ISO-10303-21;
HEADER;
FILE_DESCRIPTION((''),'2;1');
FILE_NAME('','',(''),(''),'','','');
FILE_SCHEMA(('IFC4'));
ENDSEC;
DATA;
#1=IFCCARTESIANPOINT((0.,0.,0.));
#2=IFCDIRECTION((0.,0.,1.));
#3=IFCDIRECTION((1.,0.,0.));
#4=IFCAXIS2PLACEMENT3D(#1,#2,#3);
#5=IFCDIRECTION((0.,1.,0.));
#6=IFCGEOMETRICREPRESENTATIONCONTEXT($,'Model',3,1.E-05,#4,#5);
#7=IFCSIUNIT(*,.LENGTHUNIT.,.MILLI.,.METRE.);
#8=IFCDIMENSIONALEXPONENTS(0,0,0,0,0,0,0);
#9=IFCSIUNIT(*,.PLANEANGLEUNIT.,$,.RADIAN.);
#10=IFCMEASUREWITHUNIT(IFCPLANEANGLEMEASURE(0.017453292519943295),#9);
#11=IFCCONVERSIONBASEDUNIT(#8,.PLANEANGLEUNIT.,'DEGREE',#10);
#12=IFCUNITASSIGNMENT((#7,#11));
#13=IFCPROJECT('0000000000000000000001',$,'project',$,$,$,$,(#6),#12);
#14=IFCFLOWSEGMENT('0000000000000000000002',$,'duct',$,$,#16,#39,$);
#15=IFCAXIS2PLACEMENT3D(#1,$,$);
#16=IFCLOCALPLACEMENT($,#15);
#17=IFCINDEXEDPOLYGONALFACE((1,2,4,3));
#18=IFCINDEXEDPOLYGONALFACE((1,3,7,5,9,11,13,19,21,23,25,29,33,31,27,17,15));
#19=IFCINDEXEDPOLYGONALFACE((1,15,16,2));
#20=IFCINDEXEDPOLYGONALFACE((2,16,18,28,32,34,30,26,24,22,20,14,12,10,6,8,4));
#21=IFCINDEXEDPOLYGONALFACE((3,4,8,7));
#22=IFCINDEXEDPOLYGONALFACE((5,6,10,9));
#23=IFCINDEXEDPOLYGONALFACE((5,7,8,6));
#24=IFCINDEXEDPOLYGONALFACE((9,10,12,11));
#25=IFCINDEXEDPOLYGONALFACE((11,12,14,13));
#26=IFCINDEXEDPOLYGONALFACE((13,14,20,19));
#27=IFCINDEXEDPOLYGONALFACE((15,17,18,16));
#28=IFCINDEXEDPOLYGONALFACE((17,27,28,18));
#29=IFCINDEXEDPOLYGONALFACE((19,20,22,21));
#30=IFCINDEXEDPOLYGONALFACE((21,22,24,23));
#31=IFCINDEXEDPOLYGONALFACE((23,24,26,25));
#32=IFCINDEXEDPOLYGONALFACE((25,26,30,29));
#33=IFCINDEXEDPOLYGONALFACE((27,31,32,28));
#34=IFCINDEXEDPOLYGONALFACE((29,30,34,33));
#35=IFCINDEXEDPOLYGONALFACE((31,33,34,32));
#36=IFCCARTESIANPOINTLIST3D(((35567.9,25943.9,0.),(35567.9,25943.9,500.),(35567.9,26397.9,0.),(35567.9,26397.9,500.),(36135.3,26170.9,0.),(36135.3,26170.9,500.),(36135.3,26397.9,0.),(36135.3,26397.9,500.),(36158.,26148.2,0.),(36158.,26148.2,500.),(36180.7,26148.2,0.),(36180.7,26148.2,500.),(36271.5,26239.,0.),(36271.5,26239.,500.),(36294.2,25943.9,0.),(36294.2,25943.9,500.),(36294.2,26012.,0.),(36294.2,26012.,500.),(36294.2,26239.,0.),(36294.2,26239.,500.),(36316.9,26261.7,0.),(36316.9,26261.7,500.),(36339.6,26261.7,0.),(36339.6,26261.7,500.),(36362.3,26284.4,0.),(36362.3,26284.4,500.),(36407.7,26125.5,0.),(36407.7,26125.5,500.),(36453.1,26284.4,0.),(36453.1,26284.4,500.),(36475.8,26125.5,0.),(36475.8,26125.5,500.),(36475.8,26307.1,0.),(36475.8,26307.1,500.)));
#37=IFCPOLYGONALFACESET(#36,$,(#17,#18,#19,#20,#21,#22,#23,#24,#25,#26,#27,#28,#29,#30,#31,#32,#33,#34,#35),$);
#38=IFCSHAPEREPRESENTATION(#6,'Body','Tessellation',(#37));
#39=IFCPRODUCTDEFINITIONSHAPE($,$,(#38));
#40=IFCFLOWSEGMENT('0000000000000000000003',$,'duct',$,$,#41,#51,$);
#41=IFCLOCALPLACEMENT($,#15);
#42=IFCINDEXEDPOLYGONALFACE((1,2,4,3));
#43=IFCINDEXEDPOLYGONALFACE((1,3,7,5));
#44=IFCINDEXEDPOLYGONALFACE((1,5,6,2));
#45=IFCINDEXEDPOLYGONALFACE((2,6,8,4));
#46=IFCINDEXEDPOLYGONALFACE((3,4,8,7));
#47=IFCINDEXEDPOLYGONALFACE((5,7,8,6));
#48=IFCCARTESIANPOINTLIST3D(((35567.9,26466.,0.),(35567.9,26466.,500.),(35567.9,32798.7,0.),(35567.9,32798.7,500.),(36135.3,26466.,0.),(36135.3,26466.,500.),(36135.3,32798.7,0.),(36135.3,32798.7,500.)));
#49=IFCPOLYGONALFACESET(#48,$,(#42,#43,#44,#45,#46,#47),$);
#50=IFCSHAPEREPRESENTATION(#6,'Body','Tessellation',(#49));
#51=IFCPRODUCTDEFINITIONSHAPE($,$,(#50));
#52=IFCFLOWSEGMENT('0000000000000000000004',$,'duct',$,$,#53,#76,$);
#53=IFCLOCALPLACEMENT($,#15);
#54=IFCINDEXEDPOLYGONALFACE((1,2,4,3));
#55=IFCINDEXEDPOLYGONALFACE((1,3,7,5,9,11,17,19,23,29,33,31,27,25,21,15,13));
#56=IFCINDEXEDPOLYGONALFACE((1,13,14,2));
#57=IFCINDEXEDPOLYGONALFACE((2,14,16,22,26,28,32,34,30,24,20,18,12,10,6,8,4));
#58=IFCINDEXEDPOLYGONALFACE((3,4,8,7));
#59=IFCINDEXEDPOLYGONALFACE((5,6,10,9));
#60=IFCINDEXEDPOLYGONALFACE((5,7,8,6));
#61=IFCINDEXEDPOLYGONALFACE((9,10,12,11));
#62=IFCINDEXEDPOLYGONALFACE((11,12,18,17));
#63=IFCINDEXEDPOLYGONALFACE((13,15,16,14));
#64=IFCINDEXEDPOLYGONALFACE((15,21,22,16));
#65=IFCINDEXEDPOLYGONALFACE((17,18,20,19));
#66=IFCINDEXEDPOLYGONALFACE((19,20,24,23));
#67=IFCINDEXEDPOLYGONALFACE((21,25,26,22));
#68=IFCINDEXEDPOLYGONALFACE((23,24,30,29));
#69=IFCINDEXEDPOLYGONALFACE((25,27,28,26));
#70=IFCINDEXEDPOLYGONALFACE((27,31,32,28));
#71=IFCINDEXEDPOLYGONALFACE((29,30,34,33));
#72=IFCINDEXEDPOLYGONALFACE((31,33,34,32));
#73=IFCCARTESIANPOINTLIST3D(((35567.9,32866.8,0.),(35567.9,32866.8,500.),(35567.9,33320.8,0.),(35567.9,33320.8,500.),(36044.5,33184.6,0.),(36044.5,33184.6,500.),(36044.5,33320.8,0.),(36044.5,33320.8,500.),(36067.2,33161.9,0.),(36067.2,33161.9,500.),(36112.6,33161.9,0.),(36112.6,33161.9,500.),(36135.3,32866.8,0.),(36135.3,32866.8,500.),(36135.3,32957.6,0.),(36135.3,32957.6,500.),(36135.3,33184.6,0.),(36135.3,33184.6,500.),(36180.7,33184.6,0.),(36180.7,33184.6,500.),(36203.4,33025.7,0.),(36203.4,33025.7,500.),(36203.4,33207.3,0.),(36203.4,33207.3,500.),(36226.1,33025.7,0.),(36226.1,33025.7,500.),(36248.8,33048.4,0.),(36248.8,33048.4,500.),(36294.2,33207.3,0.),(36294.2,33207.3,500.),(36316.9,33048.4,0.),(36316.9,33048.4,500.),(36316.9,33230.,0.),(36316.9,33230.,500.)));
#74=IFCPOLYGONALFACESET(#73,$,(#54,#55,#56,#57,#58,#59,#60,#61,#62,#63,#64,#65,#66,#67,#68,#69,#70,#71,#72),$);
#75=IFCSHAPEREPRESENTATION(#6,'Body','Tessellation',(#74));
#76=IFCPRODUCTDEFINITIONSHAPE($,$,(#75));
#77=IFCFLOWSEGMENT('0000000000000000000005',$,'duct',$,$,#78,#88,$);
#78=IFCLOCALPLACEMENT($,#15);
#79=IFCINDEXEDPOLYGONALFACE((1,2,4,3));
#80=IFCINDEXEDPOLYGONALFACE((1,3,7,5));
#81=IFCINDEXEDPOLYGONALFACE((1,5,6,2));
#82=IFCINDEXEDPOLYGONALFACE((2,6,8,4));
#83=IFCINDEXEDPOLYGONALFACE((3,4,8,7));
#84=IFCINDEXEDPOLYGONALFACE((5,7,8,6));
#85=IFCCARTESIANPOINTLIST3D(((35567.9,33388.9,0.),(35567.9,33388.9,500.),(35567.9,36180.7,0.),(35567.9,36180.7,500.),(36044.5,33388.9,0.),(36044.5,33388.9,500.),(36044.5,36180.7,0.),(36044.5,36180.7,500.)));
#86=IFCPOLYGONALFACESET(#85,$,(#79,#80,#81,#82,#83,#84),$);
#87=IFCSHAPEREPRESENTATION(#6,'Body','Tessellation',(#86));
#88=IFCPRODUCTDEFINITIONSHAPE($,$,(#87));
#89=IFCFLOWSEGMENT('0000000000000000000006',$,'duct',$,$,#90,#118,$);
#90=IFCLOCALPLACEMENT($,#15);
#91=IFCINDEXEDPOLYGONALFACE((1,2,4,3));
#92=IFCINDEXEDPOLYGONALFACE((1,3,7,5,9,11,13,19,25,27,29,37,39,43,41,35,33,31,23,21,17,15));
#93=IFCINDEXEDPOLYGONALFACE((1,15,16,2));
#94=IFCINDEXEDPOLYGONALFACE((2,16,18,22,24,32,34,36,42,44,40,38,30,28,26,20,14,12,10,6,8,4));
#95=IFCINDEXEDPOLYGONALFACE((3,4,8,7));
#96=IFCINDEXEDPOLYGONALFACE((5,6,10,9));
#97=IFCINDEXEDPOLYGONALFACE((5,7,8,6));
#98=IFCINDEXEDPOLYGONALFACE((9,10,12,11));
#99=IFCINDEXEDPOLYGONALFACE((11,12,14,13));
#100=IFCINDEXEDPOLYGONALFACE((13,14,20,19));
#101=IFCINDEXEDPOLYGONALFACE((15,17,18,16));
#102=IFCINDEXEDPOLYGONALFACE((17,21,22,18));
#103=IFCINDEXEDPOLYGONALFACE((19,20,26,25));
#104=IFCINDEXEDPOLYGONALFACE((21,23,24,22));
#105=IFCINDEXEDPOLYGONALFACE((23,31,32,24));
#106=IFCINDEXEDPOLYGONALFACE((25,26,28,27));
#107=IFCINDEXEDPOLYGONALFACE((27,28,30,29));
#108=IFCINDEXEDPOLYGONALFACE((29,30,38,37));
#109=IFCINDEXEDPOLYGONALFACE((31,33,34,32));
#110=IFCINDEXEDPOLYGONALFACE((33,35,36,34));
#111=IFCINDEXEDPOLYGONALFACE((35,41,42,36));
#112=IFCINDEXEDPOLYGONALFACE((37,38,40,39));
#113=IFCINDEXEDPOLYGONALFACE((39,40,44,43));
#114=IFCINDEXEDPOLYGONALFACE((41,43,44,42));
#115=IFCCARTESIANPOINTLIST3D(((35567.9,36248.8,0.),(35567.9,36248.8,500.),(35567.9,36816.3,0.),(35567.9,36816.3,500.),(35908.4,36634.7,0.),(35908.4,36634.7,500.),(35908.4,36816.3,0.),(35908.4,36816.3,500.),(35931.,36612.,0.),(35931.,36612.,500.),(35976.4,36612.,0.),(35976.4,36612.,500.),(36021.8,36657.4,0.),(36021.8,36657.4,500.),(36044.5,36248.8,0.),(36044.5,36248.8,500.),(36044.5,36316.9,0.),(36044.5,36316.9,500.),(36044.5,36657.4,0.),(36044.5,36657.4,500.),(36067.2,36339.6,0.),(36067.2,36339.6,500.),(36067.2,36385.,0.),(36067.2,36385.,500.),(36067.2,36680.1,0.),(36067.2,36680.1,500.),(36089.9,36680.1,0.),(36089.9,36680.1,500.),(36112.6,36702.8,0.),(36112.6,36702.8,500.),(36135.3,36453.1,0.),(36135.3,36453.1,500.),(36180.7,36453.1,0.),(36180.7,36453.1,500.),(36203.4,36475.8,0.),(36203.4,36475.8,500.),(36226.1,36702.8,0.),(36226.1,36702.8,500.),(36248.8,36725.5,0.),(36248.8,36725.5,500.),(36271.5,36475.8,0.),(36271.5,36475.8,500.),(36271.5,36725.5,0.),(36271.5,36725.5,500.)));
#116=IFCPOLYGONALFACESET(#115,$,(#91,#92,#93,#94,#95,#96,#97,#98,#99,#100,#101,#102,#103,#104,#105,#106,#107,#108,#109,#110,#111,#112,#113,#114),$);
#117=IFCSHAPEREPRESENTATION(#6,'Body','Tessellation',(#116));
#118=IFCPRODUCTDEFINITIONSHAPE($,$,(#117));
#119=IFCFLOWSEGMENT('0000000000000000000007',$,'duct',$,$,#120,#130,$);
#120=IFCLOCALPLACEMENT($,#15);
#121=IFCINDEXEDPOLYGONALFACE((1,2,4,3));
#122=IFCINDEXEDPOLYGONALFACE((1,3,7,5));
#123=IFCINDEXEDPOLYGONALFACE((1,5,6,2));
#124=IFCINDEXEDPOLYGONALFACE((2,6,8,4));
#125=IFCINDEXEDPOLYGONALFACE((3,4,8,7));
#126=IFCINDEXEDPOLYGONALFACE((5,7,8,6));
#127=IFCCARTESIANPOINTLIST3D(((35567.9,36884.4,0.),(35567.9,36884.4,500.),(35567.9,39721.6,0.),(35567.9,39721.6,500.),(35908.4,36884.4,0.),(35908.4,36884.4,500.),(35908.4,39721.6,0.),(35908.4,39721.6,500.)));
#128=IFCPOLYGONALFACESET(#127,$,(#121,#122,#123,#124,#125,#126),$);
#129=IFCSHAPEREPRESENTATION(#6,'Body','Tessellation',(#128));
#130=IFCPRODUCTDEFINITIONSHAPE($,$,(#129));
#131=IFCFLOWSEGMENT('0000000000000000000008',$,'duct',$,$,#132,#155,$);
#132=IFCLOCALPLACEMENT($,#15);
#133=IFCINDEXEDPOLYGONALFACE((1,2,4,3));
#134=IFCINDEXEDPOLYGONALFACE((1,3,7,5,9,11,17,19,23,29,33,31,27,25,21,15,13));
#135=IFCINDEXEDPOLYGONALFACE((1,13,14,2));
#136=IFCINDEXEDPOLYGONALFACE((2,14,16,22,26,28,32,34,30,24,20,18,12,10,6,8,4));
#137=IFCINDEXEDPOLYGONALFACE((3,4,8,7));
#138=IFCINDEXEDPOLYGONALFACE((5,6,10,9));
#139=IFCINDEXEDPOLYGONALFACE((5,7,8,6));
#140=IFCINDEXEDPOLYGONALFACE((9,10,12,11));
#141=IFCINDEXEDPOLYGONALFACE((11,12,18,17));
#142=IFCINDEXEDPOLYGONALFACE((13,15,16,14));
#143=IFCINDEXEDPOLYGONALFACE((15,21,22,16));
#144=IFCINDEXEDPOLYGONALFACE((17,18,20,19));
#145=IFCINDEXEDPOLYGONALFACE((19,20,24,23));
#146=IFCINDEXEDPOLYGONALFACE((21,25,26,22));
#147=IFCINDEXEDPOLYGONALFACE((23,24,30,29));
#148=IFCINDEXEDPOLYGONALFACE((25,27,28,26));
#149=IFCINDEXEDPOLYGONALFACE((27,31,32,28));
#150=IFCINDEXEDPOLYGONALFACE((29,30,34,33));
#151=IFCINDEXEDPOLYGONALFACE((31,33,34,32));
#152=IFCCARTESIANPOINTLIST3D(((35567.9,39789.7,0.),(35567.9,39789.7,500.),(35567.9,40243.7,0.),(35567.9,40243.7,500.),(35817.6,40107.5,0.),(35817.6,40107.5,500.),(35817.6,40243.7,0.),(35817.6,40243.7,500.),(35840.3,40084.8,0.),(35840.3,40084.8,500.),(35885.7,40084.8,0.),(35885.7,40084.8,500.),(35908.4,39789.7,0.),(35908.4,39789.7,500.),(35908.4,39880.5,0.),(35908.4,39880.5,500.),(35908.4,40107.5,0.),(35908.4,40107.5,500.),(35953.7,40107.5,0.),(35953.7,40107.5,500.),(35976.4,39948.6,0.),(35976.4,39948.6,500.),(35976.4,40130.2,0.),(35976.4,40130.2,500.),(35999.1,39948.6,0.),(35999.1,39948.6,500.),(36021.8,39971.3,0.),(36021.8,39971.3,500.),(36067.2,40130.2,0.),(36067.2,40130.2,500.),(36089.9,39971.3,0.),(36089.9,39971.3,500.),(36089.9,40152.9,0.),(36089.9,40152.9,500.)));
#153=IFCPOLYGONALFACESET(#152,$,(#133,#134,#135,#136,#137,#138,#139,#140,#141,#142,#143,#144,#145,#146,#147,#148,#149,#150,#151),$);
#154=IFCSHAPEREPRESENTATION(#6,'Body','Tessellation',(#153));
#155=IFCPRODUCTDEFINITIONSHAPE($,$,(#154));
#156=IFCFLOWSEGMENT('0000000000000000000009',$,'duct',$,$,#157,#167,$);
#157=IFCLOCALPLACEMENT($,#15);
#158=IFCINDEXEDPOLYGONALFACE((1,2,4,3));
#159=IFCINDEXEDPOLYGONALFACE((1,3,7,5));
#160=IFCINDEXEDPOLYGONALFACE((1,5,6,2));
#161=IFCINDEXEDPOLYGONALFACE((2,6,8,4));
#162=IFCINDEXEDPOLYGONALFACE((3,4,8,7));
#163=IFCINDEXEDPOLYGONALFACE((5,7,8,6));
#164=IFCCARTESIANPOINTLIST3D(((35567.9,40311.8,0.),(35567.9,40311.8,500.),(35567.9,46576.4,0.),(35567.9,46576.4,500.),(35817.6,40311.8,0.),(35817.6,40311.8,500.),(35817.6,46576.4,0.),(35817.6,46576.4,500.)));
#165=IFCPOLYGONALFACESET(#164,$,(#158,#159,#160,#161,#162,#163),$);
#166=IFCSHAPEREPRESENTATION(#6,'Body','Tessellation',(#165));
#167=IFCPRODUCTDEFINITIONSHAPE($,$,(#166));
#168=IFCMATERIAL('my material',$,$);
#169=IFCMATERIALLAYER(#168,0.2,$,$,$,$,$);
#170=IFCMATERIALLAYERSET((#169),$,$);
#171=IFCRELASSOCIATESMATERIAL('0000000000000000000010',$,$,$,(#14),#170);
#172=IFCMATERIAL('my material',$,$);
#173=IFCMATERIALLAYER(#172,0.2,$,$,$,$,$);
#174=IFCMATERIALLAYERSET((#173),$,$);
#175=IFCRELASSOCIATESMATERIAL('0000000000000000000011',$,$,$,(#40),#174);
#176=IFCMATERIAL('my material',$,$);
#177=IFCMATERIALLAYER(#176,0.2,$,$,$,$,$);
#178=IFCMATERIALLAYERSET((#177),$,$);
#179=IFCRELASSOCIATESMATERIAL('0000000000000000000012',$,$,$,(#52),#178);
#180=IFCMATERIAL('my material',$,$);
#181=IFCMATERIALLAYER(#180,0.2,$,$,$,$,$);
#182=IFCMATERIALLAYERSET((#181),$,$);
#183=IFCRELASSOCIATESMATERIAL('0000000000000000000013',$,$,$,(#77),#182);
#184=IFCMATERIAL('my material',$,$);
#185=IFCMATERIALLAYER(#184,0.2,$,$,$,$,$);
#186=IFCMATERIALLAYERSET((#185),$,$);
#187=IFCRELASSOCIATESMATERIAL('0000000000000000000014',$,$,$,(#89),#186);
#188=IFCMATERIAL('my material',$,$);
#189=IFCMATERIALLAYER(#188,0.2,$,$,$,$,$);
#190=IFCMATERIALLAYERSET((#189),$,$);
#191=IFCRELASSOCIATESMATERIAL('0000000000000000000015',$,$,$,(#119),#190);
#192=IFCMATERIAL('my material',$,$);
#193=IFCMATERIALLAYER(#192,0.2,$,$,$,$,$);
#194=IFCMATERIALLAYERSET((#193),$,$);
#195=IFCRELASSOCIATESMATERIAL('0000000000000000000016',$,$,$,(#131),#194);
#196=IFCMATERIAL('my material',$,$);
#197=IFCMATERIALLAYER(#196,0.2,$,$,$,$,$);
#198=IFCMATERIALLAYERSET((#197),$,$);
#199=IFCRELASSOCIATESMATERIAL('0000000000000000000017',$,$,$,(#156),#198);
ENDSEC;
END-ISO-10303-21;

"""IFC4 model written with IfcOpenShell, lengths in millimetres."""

from ifc_helpers import new_model, entity, si_unit, converted_unit, direction, origin_with_axes, place, context, project, polyline, outline, extrude, material, layer, layer_set, layer_usage, element, save


model = new_model("IFC4")

# Units and contexts
model_context = context("Model", 3, precision=1e-05, world=origin_with_axes(), true_north=direction((0.0, 1.0, 0.0)))
ifc_project = project(units=[si_unit("LENGTHUNIT", "METRE", prefix="MILLI"), converted_unit("PLANEANGLEUNIT", "DEGREE", entity("IfcPlaneAngleMeasure", 0.017453292519943295), si_unit("PLANEANGLEUNIT", "RADIAN"), dimensions=[0, 0, 0, 0, 0, 0, 0])], contexts=[model_context])

# Flow segments
ifc_material_1 = material(Name="my material")
ifc_layer_1 = layer(ifc_material_1, 0.2)
ifc_layer_set_1 = layer_set([ifc_layer_1])
ifc_layer_usage_1 = layer_usage(ifc_layer_set_1, "AXIS2", "POSITIVE", -0.1)
flow_segment_1_placement = place(None, origin_with_axes())
element("IfcFlowSegment", 1, at=flow_segment_1_placement, material=ifc_layer_usage_1, Name="duct", context=model_context, shape_type="SweptSolid", body=[
    extrude(outline(polyline([(35567.9, 25943.9), (36294.2, 25943.9), (36294.2, 26012.0), (36407.7, 26125.5), (36475.8, 26125.5), (36475.8, 26307.1), (36453.1, 26284.4), (36362.3, 26284.4), (36339.6, 26261.7), (36316.9, 26261.7), (36294.2, 26239.0), (36271.5, 26239.0), (36180.7, 26148.2), (36158.0, 26148.2), (36135.3, 26170.9), (36135.3, 26397.9), (35567.9, 26397.9), (35567.9, 25943.9)])), origin_with_axes(), (0.0, 0.0, 1.0), 500.0),
])
ifc_material_2 = material(Name="my material")
ifc_layer_2 = layer(ifc_material_2, 0.2)
ifc_layer_set_2 = layer_set([ifc_layer_2])
ifc_layer_usage_2 = layer_usage(ifc_layer_set_2, "AXIS2", "POSITIVE", -0.1)
flow_segment_2_placement = place(None, origin_with_axes())
element("IfcFlowSegment", 2, at=flow_segment_2_placement, material=ifc_layer_usage_2, Name="duct", context=model_context, shape_type="SweptSolid", body=[
    extrude(outline(polyline([(35567.9, 26466.0), (36135.3, 26466.0), (36135.3, 32798.7), (35567.9, 32798.7), (35567.9, 26466.0)])), origin_with_axes(), (0.0, 0.0, 1.0), 500.0),
])
ifc_material_3 = material(Name="my material")
ifc_layer_3 = layer(ifc_material_3, 0.2)
ifc_layer_set_3 = layer_set([ifc_layer_3])
ifc_layer_usage_3 = layer_usage(ifc_layer_set_3, "AXIS2", "POSITIVE", -0.1)
flow_segment_3_placement = place(None, origin_with_axes())
element("IfcFlowSegment", 3, at=flow_segment_3_placement, material=ifc_layer_usage_3, Name="duct", context=model_context, shape_type="SweptSolid", body=[
    extrude(outline(polyline([(35567.9, 32866.8), (36135.3, 32866.8), (36135.3, 32957.6), (36203.4, 33025.7), (36226.1, 33025.7), (36248.8, 33048.4), (36316.9, 33048.4), (36316.9, 33230.0), (36294.2, 33207.3), (36203.4, 33207.3), (36180.7, 33184.6), (36135.3, 33184.6), (36112.6, 33161.9), (36067.2, 33161.9), (36044.5, 33184.6), (36044.5, 33320.8), (35567.9, 33320.8), (35567.9, 32866.8)])), origin_with_axes(), (0.0, 0.0, 1.0), 500.0),
])
ifc_material_4 = material(Name="my material")
ifc_layer_4 = layer(ifc_material_4, 0.2)
ifc_layer_set_4 = layer_set([ifc_layer_4])
ifc_layer_usage_4 = layer_usage(ifc_layer_set_4, "AXIS2", "POSITIVE", -0.1)
flow_segment_4_placement = place(None, origin_with_axes())
element("IfcFlowSegment", 4, at=flow_segment_4_placement, material=ifc_layer_usage_4, Name="duct", context=model_context, shape_type="SweptSolid", body=[
    extrude(outline(polyline([(35567.9, 33388.9), (36044.5, 33388.9), (36044.5, 36180.7), (35567.9, 36180.7), (35567.9, 33388.9)])), origin_with_axes(), (0.0, 0.0, 1.0), 500.0),
])
ifc_material_5 = material(Name="my material")
ifc_layer_5 = layer(ifc_material_5, 0.2)
ifc_layer_set_5 = layer_set([ifc_layer_5])
ifc_layer_usage_5 = layer_usage(ifc_layer_set_5, "AXIS2", "POSITIVE", -0.1)
flow_segment_5_placement = place(None, origin_with_axes())
element("IfcFlowSegment", 5, at=flow_segment_5_placement, material=ifc_layer_usage_5, Name="duct", context=model_context, shape_type="SweptSolid", body=[
    extrude(outline(polyline([(35567.9, 36248.8), (36044.5, 36248.8), (36044.5, 36316.9), (36067.2, 36339.6), (36067.2, 36385.0), (36135.3, 36453.1), (36180.7, 36453.1), (36203.4, 36475.8), (36271.5, 36475.8), (36271.5, 36725.5), (36248.8, 36725.5), (36226.1, 36702.8), (36112.6, 36702.8), (36089.9, 36680.1), (36067.2, 36680.1), (36044.5, 36657.4), (36021.8, 36657.4), (35976.4, 36612.0), (35931.0, 36612.0), (35908.4, 36634.7), (35908.4, 36816.3), (35567.9, 36816.3), (35567.9, 36248.8)])), origin_with_axes(), (0.0, 0.0, 1.0), 500.0),
])
ifc_material_6 = material(Name="my material")
ifc_layer_6 = layer(ifc_material_6, 0.2)
ifc_layer_set_6 = layer_set([ifc_layer_6])
ifc_layer_usage_6 = layer_usage(ifc_layer_set_6, "AXIS2", "POSITIVE", -0.1)
flow_segment_6_placement = place(None, origin_with_axes())
element("IfcFlowSegment", 6, at=flow_segment_6_placement, material=ifc_layer_usage_6, Name="duct", context=model_context, shape_type="SweptSolid", body=[
    extrude(outline(polyline([(35567.9, 36884.4), (35908.4, 36884.4), (35908.4, 39721.6), (35567.9, 39721.6), (35567.9, 36884.4)])), origin_with_axes(), (0.0, 0.0, 1.0), 500.0),
])
ifc_material_7 = material(Name="my material")
ifc_layer_7 = layer(ifc_material_7, 0.2)
ifc_layer_set_7 = layer_set([ifc_layer_7])
ifc_layer_usage_7 = layer_usage(ifc_layer_set_7, "AXIS2", "POSITIVE", -0.1)
flow_segment_7_placement = place(None, origin_with_axes())
element("IfcFlowSegment", 7, at=flow_segment_7_placement, material=ifc_layer_usage_7, Name="duct", context=model_context, shape_type="SweptSolid", body=[
    extrude(outline(polyline([(35567.9, 39789.7), (35908.4, 39789.7), (35908.4, 39880.5), (35976.4, 39948.6), (35999.1, 39948.6), (36021.8, 39971.3), (36089.9, 39971.3), (36089.9, 40152.9), (36067.2, 40130.2), (35976.4, 40130.2), (35953.7, 40107.5), (35908.4, 40107.5), (35885.7, 40084.8), (35840.3, 40084.8), (35817.6, 40107.5), (35817.6, 40243.7), (35567.9, 40243.7), (35567.9, 39789.7)])), origin_with_axes(), (0.0, 0.0, 1.0), 500.0),
])
ifc_material_8 = material(Name="my material")
ifc_layer_8 = layer(ifc_material_8, 0.2)
ifc_layer_set_8 = layer_set([ifc_layer_8])
ifc_layer_usage_8 = layer_usage(ifc_layer_set_8, "AXIS2", "POSITIVE", -0.1)
flow_segment_8_placement = place(None, origin_with_axes())
element("IfcFlowSegment", 8, at=flow_segment_8_placement, material=ifc_layer_usage_8, Name="duct", context=model_context, shape_type="SweptSolid", body=[
    extrude(outline(polyline([(35567.9, 40311.8), (35817.6, 40311.8), (35817.6, 46576.4), (35567.9, 46576.4), (35567.9, 40311.8)])), origin_with_axes(), (0.0, 0.0, 1.0), 500.0),
])

save(model, "model.ifc")
